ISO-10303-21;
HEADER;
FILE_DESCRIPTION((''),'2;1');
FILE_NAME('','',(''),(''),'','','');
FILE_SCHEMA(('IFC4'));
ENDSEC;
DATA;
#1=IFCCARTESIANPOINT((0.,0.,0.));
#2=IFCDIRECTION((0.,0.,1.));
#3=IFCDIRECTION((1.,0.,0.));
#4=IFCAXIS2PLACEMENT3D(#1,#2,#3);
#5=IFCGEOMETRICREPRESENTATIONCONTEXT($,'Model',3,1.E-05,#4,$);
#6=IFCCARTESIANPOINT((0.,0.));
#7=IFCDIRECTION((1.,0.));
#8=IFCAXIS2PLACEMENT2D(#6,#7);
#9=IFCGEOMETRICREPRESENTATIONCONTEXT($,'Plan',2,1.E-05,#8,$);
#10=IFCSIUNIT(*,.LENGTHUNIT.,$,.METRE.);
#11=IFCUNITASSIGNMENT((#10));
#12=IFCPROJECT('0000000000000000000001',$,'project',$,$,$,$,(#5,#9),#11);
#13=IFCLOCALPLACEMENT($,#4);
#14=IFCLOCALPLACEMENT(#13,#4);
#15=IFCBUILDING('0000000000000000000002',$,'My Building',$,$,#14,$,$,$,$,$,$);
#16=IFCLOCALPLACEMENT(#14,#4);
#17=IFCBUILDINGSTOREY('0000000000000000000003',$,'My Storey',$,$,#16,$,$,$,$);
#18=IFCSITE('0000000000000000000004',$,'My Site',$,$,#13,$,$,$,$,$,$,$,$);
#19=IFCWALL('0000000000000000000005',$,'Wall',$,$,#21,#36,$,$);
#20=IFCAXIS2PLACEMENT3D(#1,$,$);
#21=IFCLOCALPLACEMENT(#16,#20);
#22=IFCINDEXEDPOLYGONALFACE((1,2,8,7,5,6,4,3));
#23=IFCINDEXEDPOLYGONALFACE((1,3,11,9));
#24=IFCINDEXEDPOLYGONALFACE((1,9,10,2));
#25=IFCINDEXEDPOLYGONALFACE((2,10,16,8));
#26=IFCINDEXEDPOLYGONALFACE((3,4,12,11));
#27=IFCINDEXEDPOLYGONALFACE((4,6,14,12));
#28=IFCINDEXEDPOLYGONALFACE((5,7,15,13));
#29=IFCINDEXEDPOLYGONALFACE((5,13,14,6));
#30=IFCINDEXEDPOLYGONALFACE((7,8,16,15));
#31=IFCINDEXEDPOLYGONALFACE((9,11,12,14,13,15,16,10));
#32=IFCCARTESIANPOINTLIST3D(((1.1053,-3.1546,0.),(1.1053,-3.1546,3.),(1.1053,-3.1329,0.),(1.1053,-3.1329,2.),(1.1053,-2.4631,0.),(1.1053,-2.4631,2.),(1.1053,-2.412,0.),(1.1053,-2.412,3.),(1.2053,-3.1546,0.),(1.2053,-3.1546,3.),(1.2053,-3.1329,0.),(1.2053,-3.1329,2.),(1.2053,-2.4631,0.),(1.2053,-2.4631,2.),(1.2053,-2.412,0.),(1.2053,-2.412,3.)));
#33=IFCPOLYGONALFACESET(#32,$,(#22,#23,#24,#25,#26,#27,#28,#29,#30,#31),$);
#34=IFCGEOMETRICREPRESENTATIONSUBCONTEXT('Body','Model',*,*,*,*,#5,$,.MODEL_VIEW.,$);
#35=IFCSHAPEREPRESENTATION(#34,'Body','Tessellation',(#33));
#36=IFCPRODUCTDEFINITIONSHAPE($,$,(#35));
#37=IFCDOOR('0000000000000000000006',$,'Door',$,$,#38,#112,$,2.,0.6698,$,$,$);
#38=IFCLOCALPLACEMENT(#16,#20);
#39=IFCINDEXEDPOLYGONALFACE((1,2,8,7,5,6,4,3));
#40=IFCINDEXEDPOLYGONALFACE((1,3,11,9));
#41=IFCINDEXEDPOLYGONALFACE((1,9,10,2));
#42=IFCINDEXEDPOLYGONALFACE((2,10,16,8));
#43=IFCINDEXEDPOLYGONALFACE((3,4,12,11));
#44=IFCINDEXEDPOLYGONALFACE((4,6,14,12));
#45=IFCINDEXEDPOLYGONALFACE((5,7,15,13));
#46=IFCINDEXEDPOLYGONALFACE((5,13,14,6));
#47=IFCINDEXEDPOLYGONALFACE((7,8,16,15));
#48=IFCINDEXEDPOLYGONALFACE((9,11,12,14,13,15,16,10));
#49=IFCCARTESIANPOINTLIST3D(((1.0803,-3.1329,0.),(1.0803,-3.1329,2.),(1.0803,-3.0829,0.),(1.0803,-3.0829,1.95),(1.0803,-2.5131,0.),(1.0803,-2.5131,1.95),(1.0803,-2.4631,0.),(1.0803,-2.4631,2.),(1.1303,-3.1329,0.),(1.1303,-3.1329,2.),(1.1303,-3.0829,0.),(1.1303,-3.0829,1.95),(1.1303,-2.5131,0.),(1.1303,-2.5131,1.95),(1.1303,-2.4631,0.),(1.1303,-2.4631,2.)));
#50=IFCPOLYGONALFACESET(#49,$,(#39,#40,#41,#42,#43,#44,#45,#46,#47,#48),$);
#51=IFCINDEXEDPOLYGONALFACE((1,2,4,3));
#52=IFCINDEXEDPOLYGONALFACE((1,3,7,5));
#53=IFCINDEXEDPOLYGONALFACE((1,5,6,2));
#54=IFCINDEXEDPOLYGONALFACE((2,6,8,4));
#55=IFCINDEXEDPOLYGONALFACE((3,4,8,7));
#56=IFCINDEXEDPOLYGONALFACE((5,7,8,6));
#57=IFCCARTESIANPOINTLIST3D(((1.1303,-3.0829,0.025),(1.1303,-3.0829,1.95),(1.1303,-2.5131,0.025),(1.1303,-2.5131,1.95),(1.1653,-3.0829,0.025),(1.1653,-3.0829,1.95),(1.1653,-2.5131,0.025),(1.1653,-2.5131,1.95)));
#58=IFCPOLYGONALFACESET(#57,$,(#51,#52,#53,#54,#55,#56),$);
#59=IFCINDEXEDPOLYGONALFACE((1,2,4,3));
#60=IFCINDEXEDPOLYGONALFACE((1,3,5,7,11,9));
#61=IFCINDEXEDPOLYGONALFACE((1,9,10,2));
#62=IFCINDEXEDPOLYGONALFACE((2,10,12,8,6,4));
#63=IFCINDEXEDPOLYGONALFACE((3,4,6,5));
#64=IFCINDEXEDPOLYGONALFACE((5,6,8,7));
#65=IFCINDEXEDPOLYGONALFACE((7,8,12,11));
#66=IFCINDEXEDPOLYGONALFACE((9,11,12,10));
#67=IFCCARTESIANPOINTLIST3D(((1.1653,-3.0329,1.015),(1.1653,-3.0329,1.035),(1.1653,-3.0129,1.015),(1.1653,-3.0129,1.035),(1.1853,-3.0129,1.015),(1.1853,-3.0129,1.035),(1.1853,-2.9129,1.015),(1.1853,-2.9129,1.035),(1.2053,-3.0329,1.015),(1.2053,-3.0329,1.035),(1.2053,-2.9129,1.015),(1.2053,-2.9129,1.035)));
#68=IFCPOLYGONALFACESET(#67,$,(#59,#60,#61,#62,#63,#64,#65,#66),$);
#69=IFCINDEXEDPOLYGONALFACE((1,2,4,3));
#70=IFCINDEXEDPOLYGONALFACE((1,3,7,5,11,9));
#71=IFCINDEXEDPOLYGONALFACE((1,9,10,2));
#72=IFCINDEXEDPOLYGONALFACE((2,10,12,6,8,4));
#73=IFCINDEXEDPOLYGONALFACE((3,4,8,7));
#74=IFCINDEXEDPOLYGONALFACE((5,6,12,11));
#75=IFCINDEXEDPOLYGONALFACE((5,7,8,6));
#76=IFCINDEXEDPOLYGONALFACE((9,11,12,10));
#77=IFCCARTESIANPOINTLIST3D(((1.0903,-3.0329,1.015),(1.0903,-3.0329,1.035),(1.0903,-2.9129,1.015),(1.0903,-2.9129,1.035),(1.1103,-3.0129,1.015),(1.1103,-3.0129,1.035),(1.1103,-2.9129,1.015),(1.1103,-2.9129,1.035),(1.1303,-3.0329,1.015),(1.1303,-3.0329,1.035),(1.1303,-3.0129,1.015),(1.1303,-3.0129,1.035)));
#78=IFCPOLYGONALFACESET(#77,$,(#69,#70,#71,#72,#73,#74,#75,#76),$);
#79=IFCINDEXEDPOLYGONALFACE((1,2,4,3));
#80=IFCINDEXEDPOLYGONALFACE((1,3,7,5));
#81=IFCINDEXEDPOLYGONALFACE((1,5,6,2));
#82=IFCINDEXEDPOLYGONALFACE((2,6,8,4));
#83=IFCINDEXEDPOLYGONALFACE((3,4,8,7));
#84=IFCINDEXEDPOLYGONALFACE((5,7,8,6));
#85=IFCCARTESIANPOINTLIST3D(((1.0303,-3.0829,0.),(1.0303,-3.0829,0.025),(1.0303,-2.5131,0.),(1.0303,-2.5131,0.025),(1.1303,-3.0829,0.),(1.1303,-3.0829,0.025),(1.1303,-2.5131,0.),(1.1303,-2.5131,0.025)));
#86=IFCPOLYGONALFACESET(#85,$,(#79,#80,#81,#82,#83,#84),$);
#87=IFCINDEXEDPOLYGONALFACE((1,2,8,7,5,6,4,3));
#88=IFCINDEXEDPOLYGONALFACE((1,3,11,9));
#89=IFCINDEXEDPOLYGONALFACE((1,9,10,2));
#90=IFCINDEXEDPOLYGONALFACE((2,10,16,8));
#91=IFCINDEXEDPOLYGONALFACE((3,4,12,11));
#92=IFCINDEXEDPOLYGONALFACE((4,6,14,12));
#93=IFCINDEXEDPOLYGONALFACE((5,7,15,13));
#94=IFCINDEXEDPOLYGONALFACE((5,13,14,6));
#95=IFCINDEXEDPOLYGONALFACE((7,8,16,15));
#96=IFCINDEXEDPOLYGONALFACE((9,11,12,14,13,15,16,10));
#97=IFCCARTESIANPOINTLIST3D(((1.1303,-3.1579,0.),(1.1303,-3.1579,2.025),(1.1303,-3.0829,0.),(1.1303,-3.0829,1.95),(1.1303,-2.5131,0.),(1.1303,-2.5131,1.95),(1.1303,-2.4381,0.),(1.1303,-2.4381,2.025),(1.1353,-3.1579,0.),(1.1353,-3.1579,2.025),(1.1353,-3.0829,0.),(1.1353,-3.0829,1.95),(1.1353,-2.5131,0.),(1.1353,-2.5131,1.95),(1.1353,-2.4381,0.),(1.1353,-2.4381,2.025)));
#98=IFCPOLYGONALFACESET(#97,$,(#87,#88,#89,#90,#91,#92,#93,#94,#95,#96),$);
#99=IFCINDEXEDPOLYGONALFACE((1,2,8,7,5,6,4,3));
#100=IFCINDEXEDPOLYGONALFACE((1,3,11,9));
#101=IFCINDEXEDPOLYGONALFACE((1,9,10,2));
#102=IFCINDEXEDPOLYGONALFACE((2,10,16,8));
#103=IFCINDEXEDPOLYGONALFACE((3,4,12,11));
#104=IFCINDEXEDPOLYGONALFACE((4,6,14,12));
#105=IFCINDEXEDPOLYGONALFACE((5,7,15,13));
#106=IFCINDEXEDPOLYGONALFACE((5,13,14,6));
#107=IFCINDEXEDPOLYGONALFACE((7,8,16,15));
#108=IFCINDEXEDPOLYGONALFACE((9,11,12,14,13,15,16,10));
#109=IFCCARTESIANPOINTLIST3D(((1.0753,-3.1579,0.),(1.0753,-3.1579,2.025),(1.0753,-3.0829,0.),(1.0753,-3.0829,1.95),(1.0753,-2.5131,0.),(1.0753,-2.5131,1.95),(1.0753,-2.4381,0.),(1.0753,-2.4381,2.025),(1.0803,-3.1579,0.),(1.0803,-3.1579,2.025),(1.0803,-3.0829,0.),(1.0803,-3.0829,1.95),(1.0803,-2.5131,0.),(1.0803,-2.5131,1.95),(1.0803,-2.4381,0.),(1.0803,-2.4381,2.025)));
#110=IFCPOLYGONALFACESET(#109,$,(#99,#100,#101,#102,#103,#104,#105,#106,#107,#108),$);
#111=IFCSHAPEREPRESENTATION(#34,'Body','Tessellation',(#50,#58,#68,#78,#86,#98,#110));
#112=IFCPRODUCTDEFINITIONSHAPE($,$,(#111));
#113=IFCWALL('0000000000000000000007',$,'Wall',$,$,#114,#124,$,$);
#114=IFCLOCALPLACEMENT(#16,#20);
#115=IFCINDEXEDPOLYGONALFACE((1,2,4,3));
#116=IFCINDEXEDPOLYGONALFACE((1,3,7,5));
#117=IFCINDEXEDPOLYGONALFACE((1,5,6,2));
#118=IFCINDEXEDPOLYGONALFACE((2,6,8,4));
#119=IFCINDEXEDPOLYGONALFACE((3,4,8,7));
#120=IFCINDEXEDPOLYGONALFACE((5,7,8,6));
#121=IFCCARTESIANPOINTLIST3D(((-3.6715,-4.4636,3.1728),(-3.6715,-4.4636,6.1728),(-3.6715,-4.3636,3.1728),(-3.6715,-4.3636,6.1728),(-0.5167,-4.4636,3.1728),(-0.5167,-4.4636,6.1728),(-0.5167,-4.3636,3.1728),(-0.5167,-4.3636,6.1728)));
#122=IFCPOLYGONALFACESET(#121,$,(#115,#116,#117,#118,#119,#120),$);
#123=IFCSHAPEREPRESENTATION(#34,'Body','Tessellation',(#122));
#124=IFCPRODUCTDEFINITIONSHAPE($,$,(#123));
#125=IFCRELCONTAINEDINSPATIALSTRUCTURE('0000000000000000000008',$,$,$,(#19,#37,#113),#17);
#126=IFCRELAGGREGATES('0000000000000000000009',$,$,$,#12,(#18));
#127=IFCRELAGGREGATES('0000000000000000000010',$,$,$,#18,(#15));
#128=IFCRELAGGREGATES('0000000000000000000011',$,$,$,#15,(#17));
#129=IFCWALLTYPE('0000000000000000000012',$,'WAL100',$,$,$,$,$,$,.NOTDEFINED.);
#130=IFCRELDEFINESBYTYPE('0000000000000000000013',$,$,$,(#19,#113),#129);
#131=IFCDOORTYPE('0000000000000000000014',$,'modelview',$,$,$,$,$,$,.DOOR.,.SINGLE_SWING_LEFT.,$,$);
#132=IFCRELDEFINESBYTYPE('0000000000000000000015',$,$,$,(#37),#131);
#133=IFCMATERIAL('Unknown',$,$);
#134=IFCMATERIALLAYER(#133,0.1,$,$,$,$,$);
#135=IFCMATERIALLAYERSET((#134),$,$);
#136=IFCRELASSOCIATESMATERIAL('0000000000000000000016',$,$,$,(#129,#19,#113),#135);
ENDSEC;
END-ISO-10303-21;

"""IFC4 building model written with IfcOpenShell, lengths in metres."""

from ifc_helpers import new_model, entity, si_unit, frame, origin_with_axes, origin_2d_with_axis, place, context, subcontext, project, spatial, line, indexed_curve, outline, extrude, shape, source, transform, mapped, material, layer, layer_set, layer_usage, type_object, type_shapes, element, fill, save


model = new_model("IFC4")

# Units and contexts
model_context = context("Model", 3, precision=1e-05, world=origin_with_axes())
plan_context = context("Plan", 2, precision=1e-05, world=origin_2d_with_axis())
body_context_1 = subcontext(model_context, "Body", "Model", "MODEL_VIEW")
body_context_2 = subcontext(plan_context, "Body", "Plan", "PLAN_VIEW")
ifc_project = project(units=[si_unit("LENGTHUNIT", "METRE")], contexts=[model_context, plan_context])

# Site, building, storey
site_placement = place(None, origin_with_axes())
site = spatial("IfcSite", under=ifc_project, at=site_placement, Name="My Site")
building_placement = place(site_placement, origin_with_axes())
building = spatial("IfcBuilding", under=site, at=building_placement, Name="My Building")
storey_placement = place(building_placement, origin_with_axes())
storey = spatial("IfcBuildingStorey", under=building, at=storey_placement, Name="My Storey")

# Shared definitions
ifc_material = material(Name="Unknown")
ifc_layer_1 = layer(ifc_material, 0.1)
ifc_layer_set_1 = layer_set([ifc_layer_1])
wall_type_1 = type_object("IfcWallType", Name="WAL100", PredefinedType="NOTDEFINED", material=ifc_layer_set_1)

# Wall, opening, door
shared_shape_1 = source(origin_with_axes(), body_context_1, "Body", "SweptSolid", [
    extrude(outline(indexed_curve([(0.0, 0.0), (0.6698, 0.0), (0.6698, 2.0), (0.0, 2.0)], segments=[line(1, 2, 3, 4, 1)])), frame((0.0, -0.6, 0.0), z_axis=(0.0, -1.0, 0.0), x_axis=(1.0, 0.0, 0.0)), (0.0, 0.0, -1.0), 1.2),
])
door_type_1 = type_object("IfcDoorType", Name="modelview", OperationType="SINGLE_SWING_LEFT", PredefinedType="DOOR")
shared_shape_2 = source(origin_with_axes(), body_context_1, "Body", "SweptSolid", [
    extrude(outline(indexed_curve([(0.0, 0.0), (0.0, 2.0), (0.6698, 2.0), (0.6698, 0.0), (0.6198, 0.0), (0.6198, 1.95), (0.05, 1.95), (0.05, 0.0)], segments=[line(1, 2, 3, 4, 5, 6, 7, 8, 1)])), frame((0.0, 0.0, 0.0), z_axis=(0.0, -1.0, 0.0), x_axis=(1.0, 0.0, 0.0)), (0.0, 0.0, -1.0), 0.05),
    extrude(outline(indexed_curve([(0.0, 0.0), (0.5698, 0.0), (0.5698, 0.035), (0.0, 0.035)], segments=[line(1, 2, 3, 4, 1)])), frame((0.05, -0.035, 0.025), z_axis=(0.0, 0.0, 1.0), x_axis=(1.0, 0.0, 0.0)), (0.0, 0.0, 1.0), 1.925),
    extrude(outline(indexed_curve([(0.0, 0.0), (0.0, -0.04), (0.12, -0.04), (0.12, -0.02), (0.02, -0.02), (0.02, 0.0)], segments=[line(1, 2, 3, 4, 5, 6, 1)])), frame((0.1, -0.035, 1.015), z_axis=(0.0, 0.0, 1.0), x_axis=(1.0, 0.0, 0.0)), (0.0, 0.0, 1.0), 0.02),
    extrude(outline(indexed_curve([(0.0, 0.0), (0.0, 0.04), (0.12, 0.04), (0.12, 0.02), (0.02, 0.02), (0.02, 0.0)], segments=[line(1, 2, 3, 4, 5, 6, 1)])), frame((0.1, 0.0, 1.015), z_axis=(0.0, 0.0, 1.0), x_axis=(1.0, 0.0, 0.0)), (0.0, 0.0, 1.0), 0.02),
    extrude(outline(indexed_curve([(0.0, 0.0), (0.5698, 0.0), (0.5698, 0.1), (0.0, 0.1)], segments=[line(1, 2, 3, 4, 1)])), frame((0.05, 0.0, 0.0), z_axis=(0.0, 0.0, 1.0), x_axis=(1.0, 0.0, 0.0)), (0.0, 0.0, 1.0), 0.025),
    extrude(outline(indexed_curve([(0.0, 0.0), (0.0, 2.025), (0.7198, 2.025), (0.7198, 0.0), (0.6448, 0.0), (0.6448, 1.95), (0.075, 1.95), (0.075, 0.0)], segments=[line(1, 2, 3, 4, 5, 6, 7, 8, 1)])), frame((-0.025, -0.005, 0.0), z_axis=(0.0, -1.0, 0.0), x_axis=(1.0, 0.0, 0.0)), (0.0, 0.0, -1.0), 0.005),
    extrude(outline(indexed_curve([(0.0, 0.0), (0.0, 2.025), (0.7198, 2.025), (0.7198, 0.0), (0.6448, 0.0), (0.6448, 1.95), (0.075, 1.95), (0.075, 0.0)], segments=[line(1, 2, 3, 4, 5, 6, 7, 8, 1)])), frame((-0.025, 0.05, 0.0), z_axis=(0.0, -1.0, 0.0), x_axis=(1.0, 0.0, 0.0)), (0.0, 0.0, -1.0), 0.005),
])
shared_shape_3 = source(origin_with_axes(), body_context_2, "Body", "Curve2D", [
    entity("IfcIndexedPolyCurve", entity("IfcCartesianPointList2D", [[0.0, 0.0], [0.05, 0.0], [0.05, 0.05], [0.0, 0.05]]), [entity("IfcLineIndex", [1, 2, 3, 4, 1])]),
    entity("IfcIndexedPolyCurve", entity("IfcCartesianPointList2D", [[0.6698, 0.0], [0.6198, 0.0], [0.6198, 0.05], [0.6698, 0.05]]), [entity("IfcLineIndex", [1, 2, 3, 4, 1])]),
    entity("IfcIndexedPolyCurve", entity("IfcCartesianPointList2D", [[0.9047, -0.035], [0.3349, -0.035], [0.3349, 0.0], [0.9047, 0.0]]), [entity("IfcLineIndex", [1, 2, 3, 4, 1])]),
])
type_shapes(door_type_1, [shared_shape_2, shared_shape_3])
ifc_layer_usage_1 = layer_usage(ifc_layer_set_1, "AXIS2", "POSITIVE", 0.0)
wall_1_placement = place(storey_placement, frame((1.2053, -3.1546, 0.0), z_axis=(0.0, 0.0, 1.0), x_axis=(0.0, 1.0, 0.0)))
wall_1 = element("IfcWall", 1, at=wall_1_placement, inside=storey, type_object=wall_type_1, material=ifc_layer_usage_1, Name="Wall", context=body_context_1, shape_type="SweptSolid", body=[
    extrude(outline(indexed_curve([(0.0, 0.0), (0.0, 0.1), (0.7426, 0.1), (0.7426, 0.0)], segments=[line(1, 2, 3, 4, 1)])), origin_with_axes(), (0.0, 0.0, 1.0), 3.0),
])
opening_1_placement = place(wall_1_placement, frame((0.0217, 0.075, 0.0), z_axis=(0.0, 0.0, 1.0), x_axis=(1.0, 0.0, 0.0)))
opening_1 = element("IfcOpeningElement", 2, at=opening_1_placement, cuts=wall_1, PredefinedType="OPENING", context=body_context_1, shape_type="MappedRepresentation", body=[
    mapped(shared_shape_1, transform((0.0, 0.0, 0.0), x_axis=(1.0, 0.0, 0.0), y_axis=(0.0, 1.0, 0.0), z_axis=(0.0, 0.0, 1.0), scale=1.0)),
])
door_1_placement = place(opening_1_placement, frame((0.0, 0.0, 0.0), z_axis=(0.0, 0.0, 1.0), x_axis=(1.0, 0.0, 0.0)))
door_1 = element("IfcDoor", 3, at=door_1_placement, inside=storey, type_object=door_type_1, Name="Door", OverallHeight=2.0, OverallWidth=0.6698, shapes=[
    shape(body_context_1, "Body", "MappedRepresentation", [mapped(shared_shape_2, transform((0.0, 0.0, 0.0), x_axis=(1.0, 0.0, 0.0), y_axis=(0.0, 1.0, 0.0), z_axis=(0.0, 0.0, 1.0), scale=1.0))]),
    shape(body_context_2, "Body", "MappedRepresentation", [mapped(shared_shape_3, transform((0.0, 0.0, 0.0), x_axis=(1.0, 0.0, 0.0), y_axis=(0.0, 1.0, 0.0), z_axis=(0.0, 0.0, 1.0), scale=1.0))]),
])
fill(opening_1, door_1)

# Wall
ifc_layer_usage_2 = layer_usage(ifc_layer_set_1, "AXIS2", "POSITIVE", 0.0)
wall_2_placement = place(storey_placement, frame((-3.6715, -4.4636, 3.1728), z_axis=(0.0, 0.0, 1.0), x_axis=(1.0, 0.0, 0.0)))
element("IfcWall", 4, at=wall_2_placement, inside=storey, type_object=wall_type_1, material=ifc_layer_usage_2, Name="Wall", context=body_context_1, shape_type="SweptSolid", body=[
    extrude(outline(indexed_curve([(0.0, 0.0), (0.0, 0.1), (3.1548, 0.1), (3.1548, 0.0)], segments=[line(1, 2, 3, 4, 1)])), origin_with_axes(), (0.0, 0.0, 1.0), 3.0),
])

save(model, "model.ifc")
